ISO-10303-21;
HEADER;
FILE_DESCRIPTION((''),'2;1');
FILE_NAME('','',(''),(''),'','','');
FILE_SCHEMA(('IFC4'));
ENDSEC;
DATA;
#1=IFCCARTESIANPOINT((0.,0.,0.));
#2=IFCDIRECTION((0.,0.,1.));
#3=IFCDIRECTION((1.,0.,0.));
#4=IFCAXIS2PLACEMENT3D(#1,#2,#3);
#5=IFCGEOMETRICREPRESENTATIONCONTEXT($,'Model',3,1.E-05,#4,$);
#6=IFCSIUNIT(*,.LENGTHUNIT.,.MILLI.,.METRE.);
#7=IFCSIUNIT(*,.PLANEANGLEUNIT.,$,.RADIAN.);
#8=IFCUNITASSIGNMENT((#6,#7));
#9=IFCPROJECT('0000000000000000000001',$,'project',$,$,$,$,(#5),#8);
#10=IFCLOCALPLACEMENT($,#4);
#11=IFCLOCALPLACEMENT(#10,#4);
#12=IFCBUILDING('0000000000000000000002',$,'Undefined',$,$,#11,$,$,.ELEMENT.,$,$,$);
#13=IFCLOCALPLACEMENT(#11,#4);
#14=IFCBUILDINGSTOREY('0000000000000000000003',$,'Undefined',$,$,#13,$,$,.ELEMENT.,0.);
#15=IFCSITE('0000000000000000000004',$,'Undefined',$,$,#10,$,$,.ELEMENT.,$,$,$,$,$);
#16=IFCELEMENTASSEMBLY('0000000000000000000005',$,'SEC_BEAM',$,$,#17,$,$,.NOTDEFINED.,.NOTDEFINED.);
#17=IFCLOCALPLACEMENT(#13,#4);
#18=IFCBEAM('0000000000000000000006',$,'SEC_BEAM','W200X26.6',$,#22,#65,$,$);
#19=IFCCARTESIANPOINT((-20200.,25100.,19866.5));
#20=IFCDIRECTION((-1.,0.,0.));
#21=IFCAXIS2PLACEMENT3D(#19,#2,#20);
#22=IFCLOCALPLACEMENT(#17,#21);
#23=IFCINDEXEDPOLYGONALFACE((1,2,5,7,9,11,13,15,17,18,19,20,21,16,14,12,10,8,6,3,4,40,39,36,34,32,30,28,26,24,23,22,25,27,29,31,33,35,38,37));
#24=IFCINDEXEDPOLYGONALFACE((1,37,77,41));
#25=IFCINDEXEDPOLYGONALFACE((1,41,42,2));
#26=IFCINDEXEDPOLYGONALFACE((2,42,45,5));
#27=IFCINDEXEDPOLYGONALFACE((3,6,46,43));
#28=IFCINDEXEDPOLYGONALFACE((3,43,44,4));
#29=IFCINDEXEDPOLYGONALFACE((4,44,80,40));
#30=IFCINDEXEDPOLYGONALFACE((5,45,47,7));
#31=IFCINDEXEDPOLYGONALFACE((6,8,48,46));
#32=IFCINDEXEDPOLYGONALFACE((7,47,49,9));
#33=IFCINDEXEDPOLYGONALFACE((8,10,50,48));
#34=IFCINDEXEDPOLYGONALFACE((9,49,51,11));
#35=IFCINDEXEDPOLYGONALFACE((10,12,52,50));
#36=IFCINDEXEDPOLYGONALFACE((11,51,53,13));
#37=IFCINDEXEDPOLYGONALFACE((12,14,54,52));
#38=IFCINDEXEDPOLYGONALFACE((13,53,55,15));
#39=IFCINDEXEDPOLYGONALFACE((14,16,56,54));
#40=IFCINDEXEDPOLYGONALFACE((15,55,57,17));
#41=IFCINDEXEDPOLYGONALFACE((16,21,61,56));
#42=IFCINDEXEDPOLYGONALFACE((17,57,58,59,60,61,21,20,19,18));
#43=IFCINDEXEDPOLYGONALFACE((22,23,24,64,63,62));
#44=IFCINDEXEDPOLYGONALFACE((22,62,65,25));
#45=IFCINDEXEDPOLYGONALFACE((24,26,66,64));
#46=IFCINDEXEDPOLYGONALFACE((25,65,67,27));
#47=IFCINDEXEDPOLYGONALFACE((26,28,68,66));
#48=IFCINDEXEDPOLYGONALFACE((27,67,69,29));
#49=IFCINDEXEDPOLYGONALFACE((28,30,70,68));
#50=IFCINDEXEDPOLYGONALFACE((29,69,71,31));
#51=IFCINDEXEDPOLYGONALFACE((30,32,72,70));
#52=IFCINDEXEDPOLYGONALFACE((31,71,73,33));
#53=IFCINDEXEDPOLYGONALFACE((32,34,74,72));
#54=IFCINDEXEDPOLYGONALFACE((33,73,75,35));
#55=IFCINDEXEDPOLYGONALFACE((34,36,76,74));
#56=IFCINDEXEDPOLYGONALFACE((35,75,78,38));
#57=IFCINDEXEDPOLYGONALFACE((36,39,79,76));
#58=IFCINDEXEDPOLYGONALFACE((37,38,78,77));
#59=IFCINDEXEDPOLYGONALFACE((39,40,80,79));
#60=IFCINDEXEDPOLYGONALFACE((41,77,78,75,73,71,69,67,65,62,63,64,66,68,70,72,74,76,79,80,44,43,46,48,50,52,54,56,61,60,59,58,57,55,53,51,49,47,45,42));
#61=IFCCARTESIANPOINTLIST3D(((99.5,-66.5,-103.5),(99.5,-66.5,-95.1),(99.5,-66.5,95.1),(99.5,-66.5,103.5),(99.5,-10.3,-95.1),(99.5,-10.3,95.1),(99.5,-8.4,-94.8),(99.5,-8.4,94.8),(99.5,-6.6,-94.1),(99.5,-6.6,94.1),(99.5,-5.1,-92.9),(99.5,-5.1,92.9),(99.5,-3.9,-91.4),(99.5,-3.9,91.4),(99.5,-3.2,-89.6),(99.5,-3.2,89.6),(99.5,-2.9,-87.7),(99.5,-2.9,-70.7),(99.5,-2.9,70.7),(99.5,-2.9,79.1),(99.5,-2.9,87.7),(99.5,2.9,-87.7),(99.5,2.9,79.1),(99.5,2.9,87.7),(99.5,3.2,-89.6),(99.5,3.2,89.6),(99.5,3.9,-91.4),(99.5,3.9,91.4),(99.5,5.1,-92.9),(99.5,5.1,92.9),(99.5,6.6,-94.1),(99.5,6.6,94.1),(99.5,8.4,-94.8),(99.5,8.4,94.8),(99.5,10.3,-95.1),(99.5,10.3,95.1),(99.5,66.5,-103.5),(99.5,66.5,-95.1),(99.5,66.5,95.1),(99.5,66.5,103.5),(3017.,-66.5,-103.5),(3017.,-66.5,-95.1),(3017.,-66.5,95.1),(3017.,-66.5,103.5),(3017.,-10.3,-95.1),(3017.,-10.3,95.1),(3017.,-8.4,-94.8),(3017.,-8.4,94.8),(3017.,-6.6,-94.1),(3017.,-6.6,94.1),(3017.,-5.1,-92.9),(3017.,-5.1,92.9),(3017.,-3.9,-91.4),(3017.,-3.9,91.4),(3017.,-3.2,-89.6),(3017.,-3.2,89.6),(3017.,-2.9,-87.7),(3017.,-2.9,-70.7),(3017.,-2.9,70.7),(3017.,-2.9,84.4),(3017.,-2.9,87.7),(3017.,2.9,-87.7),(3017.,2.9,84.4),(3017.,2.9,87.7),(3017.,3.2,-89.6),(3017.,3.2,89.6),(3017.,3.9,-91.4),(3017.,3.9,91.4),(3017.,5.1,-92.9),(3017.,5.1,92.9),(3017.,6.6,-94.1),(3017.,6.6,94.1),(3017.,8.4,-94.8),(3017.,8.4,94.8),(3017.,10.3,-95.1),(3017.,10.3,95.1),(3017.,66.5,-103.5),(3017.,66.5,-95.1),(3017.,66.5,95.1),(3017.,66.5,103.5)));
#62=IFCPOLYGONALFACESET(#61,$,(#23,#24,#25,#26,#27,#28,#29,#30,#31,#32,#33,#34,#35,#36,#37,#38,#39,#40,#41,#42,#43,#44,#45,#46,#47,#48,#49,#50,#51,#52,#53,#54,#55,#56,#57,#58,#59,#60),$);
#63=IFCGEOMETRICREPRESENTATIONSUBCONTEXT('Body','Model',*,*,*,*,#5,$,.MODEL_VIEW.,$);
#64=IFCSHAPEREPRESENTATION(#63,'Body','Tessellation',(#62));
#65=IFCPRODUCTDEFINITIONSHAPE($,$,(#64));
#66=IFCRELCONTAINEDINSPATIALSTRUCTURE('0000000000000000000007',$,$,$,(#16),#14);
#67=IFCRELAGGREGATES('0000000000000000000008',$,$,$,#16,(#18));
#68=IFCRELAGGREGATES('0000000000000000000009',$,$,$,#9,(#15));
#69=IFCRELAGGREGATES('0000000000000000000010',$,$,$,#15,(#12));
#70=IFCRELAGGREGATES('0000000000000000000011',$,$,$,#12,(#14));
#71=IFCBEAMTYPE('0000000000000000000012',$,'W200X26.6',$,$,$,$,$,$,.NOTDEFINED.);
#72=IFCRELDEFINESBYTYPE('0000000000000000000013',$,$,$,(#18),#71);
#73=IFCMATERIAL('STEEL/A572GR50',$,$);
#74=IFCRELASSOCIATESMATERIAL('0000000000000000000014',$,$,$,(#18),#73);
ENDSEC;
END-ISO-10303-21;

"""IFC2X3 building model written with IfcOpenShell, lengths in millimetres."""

from ifc_helpers import new_model, si_unit, frame, origin_with_axes, origin_2d_with_axis, place, context, subcontext, project, spatial, polyline, rectangle, i_section, outline, extrude, boolean, halfspace, material, type_object, element, aggregate, save


model = new_model("IFC2X3")

# Units and contexts
model_context = context("Model", 3, precision=1e-05, world=origin_with_axes())
body_context = subcontext(model_context, "Body", "Model", "MODEL_VIEW")
ifc_project = project(units=[si_unit("LENGTHUNIT", "METRE", prefix="MILLI"), si_unit("PLANEANGLEUNIT", "RADIAN")], contexts=[model_context])

# Site, building, storey
site_placement = place(None, origin_with_axes())
site = spatial("IfcSite", under=ifc_project, at=site_placement, Name="Undefined", CompositionType="ELEMENT")
building_placement = place(site_placement, origin_with_axes())
building = spatial("IfcBuilding", under=site, at=building_placement, Name="Undefined", CompositionType="ELEMENT")
storey_placement = place(building_placement, origin_with_axes())
storey = spatial("IfcBuildingStorey", under=building, at=storey_placement, Name="Undefined", CompositionType="ELEMENT", Elevation=0.0)

# Element assembly, beam
ifc_material_1 = material(Name="STEEL/A572GR50")
beam_type_1 = type_object("IfcBeamType", Name="W200X26.6", PredefinedType="NOTDEFINED")
assembly_1_placement = place(storey_placement, origin_with_axes())
assembly_1 = element("IfcElementAssembly", 1, at=assembly_1_placement, inside=storey, Name="SEC_BEAM", AssemblyPlace="NOTDEFINED", PredefinedType="NOTDEFINED")
beam_1_placement = place(assembly_1_placement, frame((-20200.0, 25100.0, 19866.5), z_axis=(0.0, 0.0, 1.0), x_axis=(-1.0, 0.0, 0.0)))
beam_1 = element("IfcBeam", 2, at=beam_1_placement, type_object=beam_type_1, material=ifc_material_1, Name="SEC_BEAM", Description="W200X26.6", context=body_context, shape_type="CSG", body=[
    boolean("DIFFERENCE", boolean("DIFFERENCE", boolean("DIFFERENCE", boolean("DIFFERENCE", boolean("DIFFERENCE", boolean("DIFFERENCE", extrude(i_section(OverallWidth=133.0, OverallDepth=207.0, WebThickness=5.8, FlangeThickness=8.4, FilletRadius=7.4, at=origin_2d_with_axis()), frame((3100.0, 0.0, 0.0), z_axis=(-1.0, 0.0, 0.0), x_axis=(0.0, -1.0, 0.0)), (0.0, 0.0, 1.0), 3100.0), extrude(outline(polyline([(0.0, 0.0), (34.4, 0.0), (34.4, 10.0), (0.0, 10.0), (0.0, 0.0)])), frame((99.5, 76.5, 79.1), z_axis=(0.0, -1.0, 0.0), x_axis=(0.0, 0.0, 1.0)), (0.0, 0.0, 1.0), 153.0)), extrude(rectangle(XDim=165.1, YDim=165.1, at=origin_2d_with_axis()), frame((87.0, -85.5, 70.7), z_axis=(0.0, 0.0, -1.0), x_axis=(1.0, 0.0, 0.0)), (0.0, 0.0, 1.0), 141.5)), extrude(outline(polyline([(0.0, 0.0), (29.1, 0.0), (29.1, 10.0), (0.0, 10.0), (0.0, 0.0)])), frame((3017.0, -76.5, 84.4), z_axis=(0.0, 1.0, 0.0), x_axis=(0.0, 0.0, 1.0)), (0.0, 0.0, 1.0), 153.0)), extrude(rectangle(XDim=149.9, YDim=149.9, at=origin_2d_with_axis()), frame((3022.0, -77.9, 70.7), z_axis=(0.0, 0.0, -1.0), x_axis=(-1.0, 0.0, 0.0)), (0.0, 0.0, 1.0), 141.5)), halfspace(frame((3017.0, 0.0, 203.5), z_axis=(1.0, 0.0, 0.0), x_axis=(0.0, 1.0, 0.0)), False)), halfspace(frame((99.5, 0.0, 203.5), z_axis=(-1.0, 0.0, 0.0), x_axis=(0.0, -1.0, 0.0)), False)),
])

aggregate(assembly_1, [beam_1])

save(model, "model.ifc")
